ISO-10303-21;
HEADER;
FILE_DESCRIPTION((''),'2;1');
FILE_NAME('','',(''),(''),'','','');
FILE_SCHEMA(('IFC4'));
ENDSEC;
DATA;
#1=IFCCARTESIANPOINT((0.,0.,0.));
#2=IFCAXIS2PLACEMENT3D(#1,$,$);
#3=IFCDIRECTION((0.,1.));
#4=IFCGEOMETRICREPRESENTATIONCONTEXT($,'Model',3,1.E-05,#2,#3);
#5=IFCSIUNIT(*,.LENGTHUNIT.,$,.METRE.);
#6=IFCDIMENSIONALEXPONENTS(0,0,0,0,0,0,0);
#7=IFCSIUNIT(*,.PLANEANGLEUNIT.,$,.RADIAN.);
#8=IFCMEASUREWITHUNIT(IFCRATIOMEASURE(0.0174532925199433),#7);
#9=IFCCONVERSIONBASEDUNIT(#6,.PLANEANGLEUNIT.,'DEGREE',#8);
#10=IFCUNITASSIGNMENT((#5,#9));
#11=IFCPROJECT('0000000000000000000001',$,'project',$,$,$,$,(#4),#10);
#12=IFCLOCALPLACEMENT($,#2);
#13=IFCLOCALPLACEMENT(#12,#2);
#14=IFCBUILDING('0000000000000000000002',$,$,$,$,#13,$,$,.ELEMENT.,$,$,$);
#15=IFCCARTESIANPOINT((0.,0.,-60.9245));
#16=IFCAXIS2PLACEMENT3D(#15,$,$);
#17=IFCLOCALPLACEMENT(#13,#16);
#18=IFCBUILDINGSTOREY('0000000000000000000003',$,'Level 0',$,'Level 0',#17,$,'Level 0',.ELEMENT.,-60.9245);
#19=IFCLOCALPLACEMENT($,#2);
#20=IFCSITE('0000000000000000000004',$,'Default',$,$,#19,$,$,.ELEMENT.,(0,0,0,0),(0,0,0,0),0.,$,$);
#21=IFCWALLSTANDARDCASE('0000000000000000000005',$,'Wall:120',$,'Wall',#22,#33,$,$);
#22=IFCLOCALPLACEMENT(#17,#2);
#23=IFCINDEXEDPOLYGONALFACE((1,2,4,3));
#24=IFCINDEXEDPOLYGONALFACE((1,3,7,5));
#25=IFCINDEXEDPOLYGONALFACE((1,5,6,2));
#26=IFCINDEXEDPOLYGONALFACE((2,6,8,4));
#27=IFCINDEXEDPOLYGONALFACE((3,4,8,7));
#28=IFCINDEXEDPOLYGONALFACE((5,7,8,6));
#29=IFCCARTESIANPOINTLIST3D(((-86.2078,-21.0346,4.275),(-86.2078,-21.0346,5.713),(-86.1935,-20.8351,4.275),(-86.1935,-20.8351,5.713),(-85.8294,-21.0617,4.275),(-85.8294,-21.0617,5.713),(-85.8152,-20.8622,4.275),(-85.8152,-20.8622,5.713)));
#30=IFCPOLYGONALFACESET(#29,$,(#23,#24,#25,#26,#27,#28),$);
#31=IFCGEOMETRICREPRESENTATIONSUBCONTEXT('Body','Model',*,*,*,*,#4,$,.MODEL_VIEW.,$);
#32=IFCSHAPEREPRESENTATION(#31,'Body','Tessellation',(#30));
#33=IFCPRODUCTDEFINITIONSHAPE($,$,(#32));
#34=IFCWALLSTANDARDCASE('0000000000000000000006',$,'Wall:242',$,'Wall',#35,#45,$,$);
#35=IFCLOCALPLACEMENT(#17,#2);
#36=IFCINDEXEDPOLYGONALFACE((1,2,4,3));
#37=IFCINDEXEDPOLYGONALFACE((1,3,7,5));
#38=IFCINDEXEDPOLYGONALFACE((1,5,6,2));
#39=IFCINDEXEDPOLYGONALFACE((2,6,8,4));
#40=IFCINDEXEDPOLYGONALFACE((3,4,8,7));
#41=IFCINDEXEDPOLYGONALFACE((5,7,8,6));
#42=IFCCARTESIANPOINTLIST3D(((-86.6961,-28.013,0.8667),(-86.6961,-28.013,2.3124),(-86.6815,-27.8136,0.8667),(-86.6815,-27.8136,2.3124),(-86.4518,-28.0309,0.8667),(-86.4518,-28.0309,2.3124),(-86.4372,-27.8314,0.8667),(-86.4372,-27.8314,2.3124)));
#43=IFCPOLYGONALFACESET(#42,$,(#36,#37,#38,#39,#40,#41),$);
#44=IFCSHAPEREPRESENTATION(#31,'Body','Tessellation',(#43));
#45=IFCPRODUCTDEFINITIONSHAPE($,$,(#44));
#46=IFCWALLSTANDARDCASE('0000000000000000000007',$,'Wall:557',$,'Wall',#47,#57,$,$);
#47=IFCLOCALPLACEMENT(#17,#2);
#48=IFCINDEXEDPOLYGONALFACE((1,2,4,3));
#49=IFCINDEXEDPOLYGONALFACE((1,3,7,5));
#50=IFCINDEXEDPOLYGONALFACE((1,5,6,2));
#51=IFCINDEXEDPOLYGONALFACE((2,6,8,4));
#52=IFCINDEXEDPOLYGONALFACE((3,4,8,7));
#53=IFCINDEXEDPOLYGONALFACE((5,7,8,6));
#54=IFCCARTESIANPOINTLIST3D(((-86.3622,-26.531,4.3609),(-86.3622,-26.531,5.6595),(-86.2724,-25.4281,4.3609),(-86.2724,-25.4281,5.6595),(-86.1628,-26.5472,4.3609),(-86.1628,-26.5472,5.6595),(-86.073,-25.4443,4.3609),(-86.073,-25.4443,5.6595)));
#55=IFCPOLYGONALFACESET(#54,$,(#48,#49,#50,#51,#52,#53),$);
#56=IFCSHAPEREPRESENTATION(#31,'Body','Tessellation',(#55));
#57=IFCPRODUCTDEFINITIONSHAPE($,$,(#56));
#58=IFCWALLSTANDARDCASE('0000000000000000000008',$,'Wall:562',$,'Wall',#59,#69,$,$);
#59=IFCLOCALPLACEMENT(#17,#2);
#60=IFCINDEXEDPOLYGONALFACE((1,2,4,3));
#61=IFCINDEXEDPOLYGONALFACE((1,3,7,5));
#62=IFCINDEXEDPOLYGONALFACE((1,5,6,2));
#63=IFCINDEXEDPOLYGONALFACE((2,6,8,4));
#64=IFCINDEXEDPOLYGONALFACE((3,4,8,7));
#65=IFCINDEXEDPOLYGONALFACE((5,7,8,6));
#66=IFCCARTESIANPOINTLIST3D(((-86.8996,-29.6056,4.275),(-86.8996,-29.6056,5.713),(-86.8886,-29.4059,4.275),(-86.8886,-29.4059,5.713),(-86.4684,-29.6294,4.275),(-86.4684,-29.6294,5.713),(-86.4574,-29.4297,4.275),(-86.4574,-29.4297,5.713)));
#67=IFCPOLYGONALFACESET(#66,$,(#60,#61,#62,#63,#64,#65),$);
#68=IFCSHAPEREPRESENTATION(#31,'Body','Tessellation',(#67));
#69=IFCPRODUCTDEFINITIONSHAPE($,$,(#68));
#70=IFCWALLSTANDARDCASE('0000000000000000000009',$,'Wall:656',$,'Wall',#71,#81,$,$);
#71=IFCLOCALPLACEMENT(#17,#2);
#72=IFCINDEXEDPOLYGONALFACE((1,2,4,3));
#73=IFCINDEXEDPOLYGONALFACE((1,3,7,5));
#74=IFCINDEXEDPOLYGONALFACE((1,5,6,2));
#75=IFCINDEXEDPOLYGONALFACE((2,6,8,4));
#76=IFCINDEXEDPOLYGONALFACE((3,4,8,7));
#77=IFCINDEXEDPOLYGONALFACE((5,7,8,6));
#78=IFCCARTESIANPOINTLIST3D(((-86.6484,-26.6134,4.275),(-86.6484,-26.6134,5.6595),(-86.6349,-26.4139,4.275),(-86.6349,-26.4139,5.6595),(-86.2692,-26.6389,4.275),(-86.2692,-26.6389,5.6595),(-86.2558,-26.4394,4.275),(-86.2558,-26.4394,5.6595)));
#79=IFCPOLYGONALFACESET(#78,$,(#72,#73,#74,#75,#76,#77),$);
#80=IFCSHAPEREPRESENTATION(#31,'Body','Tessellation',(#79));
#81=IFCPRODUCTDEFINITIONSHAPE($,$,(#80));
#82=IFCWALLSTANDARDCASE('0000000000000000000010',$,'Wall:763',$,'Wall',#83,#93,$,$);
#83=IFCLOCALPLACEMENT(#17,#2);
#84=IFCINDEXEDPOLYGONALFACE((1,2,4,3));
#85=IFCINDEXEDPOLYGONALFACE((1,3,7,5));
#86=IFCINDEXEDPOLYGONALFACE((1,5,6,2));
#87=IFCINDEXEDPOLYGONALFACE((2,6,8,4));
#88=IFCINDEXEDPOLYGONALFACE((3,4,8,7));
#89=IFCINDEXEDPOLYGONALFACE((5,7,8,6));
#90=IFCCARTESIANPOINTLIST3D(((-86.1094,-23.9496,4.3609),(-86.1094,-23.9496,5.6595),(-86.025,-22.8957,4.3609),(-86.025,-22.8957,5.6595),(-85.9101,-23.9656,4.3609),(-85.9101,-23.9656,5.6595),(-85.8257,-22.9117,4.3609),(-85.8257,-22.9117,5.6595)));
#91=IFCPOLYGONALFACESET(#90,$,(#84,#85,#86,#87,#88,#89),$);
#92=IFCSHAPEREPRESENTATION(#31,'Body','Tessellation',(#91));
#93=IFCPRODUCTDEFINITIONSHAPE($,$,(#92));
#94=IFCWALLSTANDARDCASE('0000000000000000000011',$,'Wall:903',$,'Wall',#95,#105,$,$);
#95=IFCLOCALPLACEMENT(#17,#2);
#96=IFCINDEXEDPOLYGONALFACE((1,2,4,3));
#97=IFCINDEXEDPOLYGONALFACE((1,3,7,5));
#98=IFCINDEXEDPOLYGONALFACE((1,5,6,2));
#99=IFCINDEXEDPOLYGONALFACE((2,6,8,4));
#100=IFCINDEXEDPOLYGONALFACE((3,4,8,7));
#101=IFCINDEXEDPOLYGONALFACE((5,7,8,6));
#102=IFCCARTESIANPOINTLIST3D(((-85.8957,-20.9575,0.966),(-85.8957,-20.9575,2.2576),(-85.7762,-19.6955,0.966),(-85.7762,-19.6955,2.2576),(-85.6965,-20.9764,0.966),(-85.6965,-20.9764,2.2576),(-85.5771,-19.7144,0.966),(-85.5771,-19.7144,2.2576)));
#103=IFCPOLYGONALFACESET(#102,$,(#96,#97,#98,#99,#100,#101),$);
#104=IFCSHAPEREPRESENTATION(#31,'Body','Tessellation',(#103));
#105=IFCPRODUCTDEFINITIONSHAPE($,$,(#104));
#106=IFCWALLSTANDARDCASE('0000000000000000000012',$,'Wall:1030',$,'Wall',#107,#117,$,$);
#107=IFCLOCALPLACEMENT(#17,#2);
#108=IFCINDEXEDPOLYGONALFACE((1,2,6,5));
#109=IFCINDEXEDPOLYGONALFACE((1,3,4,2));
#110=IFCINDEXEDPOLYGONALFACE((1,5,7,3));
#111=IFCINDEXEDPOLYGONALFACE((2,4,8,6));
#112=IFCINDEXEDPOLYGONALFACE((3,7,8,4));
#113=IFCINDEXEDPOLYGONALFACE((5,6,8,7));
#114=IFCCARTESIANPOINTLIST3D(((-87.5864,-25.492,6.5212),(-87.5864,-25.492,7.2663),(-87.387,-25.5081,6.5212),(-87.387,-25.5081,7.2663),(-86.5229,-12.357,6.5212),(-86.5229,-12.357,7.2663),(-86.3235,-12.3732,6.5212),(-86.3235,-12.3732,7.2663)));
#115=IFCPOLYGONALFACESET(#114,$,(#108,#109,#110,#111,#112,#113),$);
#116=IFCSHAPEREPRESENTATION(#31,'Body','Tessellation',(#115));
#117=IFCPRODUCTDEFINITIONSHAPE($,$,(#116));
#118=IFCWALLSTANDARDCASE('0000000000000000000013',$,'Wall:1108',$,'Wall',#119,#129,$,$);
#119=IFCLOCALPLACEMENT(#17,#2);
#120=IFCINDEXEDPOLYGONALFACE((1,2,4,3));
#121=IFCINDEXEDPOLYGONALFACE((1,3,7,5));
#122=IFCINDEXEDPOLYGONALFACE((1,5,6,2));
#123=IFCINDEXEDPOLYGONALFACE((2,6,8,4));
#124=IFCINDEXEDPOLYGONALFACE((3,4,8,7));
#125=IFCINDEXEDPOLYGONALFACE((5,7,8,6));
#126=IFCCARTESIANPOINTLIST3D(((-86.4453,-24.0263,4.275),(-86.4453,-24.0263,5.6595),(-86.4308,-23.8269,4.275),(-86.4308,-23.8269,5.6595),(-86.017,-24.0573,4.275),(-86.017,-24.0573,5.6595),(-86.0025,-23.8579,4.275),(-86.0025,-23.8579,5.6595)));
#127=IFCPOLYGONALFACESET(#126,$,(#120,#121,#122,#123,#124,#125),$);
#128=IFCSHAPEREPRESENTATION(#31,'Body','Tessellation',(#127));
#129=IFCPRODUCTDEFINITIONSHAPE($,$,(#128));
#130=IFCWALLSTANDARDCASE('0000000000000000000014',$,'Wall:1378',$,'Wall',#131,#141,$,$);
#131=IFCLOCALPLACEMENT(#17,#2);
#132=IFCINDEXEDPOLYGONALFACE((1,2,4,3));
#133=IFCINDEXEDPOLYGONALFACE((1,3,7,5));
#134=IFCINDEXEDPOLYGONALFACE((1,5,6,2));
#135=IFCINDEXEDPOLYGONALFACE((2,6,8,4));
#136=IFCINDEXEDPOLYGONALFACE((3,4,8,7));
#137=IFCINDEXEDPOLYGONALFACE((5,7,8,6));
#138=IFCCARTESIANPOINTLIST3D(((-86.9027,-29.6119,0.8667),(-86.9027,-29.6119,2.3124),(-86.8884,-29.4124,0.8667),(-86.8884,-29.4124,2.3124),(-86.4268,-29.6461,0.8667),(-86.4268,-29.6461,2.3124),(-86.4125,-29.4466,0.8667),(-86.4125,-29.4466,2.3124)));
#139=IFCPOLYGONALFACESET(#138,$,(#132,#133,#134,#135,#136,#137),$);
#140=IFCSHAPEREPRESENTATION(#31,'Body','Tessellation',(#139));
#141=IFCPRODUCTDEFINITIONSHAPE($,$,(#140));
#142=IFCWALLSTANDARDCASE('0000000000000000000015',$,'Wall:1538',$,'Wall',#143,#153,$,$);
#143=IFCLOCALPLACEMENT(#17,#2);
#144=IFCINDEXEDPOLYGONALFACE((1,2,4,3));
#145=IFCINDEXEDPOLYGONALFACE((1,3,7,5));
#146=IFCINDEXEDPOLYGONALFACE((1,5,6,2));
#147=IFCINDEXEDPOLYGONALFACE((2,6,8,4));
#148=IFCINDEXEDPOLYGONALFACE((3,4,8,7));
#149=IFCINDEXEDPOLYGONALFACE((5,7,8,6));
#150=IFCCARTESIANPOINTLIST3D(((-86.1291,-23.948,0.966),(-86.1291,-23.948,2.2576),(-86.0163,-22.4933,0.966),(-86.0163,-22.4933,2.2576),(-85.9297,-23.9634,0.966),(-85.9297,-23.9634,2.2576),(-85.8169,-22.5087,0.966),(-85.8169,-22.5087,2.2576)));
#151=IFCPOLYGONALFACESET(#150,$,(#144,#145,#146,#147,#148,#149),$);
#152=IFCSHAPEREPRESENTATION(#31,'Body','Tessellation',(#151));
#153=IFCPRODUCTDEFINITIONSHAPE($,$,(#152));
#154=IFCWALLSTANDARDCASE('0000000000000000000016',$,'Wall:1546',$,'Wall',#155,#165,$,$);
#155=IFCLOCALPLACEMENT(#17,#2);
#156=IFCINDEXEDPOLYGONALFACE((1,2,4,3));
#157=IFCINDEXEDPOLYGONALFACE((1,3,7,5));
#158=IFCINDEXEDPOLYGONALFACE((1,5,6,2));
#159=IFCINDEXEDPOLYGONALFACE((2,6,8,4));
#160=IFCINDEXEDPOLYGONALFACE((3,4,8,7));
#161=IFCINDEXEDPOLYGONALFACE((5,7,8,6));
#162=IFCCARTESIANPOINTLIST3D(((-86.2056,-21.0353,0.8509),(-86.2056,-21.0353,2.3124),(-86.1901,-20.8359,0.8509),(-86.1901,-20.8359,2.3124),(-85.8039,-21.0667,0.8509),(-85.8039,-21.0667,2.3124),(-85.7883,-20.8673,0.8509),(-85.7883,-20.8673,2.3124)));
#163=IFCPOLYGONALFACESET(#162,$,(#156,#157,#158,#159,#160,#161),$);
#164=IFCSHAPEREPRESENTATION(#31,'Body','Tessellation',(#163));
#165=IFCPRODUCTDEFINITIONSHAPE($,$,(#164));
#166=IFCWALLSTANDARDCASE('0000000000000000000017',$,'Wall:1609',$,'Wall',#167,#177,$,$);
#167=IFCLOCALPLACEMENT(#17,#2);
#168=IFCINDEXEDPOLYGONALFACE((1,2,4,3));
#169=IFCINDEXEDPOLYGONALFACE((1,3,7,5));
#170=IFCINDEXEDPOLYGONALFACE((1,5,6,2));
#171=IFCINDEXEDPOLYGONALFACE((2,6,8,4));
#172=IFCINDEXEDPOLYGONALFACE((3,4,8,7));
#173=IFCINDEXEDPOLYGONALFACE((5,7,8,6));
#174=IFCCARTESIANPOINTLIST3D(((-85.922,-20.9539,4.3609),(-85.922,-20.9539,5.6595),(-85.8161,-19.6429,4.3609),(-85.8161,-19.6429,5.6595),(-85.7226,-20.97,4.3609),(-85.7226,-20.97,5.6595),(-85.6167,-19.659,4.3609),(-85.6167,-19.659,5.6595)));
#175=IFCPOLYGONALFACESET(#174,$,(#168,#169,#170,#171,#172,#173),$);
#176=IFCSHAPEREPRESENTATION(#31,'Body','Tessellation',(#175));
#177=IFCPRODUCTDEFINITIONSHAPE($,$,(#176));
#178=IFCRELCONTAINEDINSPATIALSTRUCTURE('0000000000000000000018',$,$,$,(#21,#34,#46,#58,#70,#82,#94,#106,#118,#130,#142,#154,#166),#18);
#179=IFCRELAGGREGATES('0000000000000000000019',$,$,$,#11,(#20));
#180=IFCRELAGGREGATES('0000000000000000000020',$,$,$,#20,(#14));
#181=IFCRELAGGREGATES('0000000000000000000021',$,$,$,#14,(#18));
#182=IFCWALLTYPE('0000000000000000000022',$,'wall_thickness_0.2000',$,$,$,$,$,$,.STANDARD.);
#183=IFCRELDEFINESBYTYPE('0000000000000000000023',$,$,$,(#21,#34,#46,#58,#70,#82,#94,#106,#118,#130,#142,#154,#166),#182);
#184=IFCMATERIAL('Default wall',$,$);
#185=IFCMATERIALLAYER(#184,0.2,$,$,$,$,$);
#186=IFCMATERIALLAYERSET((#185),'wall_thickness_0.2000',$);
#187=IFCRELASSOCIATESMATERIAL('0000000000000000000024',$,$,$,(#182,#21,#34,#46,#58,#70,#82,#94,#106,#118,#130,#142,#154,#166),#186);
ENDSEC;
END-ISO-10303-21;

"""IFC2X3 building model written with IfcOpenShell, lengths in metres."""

from ifc_helpers import new_model, entity, si_unit, converted_unit, direction, frame, origin, place, context, subcontext, project, spatial, polyline, outline, extrude, material, layer, layer_set, layer_usage, type_object, element, save


model = new_model("IFC2X3")

# Units and contexts
model_context = context("Model", 3, precision=1e-05, world=origin(), true_north=direction((0.0, 1.0)))
body_context = subcontext(model_context, "Body", "Model", "MODEL_VIEW")
ifc_project = project(units=[si_unit("LENGTHUNIT", "METRE"), converted_unit("PLANEANGLEUNIT", "DEGREE", entity("IfcRatioMeasure", 0.0174532925199433), si_unit("PLANEANGLEUNIT", "RADIAN"), dimensions=[0, 0, 0, 0, 0, 0, 0])], contexts=[model_context])

# Site, building, storey
site_placement = place(None, origin())
site = spatial("IfcSite", under=ifc_project, at=site_placement, Name="Default", CompositionType="ELEMENT", RefLatitude=(0, 0, 0, 0), RefLongitude=(0, 0, 0, 0), RefElevation=0.0)
placement_1 = place(None, origin())
building_placement = place(placement_1, origin())
building = spatial("IfcBuilding", under=site, at=building_placement, CompositionType="ELEMENT")
storey_placement = place(building_placement, frame((0.0, 0.0, -60.9245)))
storey = spatial("IfcBuildingStorey", under=building, at=storey_placement, Name="Level 0", ObjectType="Level 0", LongName="Level 0", CompositionType="ELEMENT", Elevation=-60.9245)

# Walls
ifc_material = material(Name="Default wall")
ifc_layer = layer(ifc_material, 0.2)
ifc_layer_set = layer_set([ifc_layer], Name="wall_thickness_0.2000")
ifc_layer_usage = layer_usage(ifc_layer_set, "AXIS2", "POSITIVE", -0.1)
wall_type = type_object("IfcWallType", Name="wall_thickness_0.2000", PredefinedType="STANDARD", material=ifc_layer_set)
placement_2 = place(building_placement, frame((0.0, 0.0, -56.6495)))
wall_1_placement = place(placement_2, frame((-85.8223, -20.9619, 0.0), z_axis=(0.0, 0.0, 1.0), x_axis=(-0.997445, 0.071444, 0.0)))
element("IfcWallStandardCase", 1, at=wall_1_placement, inside=storey, type_object=wall_type, material=ifc_layer_usage, Name="Wall:120", ObjectType="Wall", context=body_context, shape_type="SweptSolid", body=[
    extrude(outline(polyline([(0.3793, -0.1), (0.3793, 0.1), (0.0, 0.1), (0.0, -0.1), (0.3793, -0.1)])), origin(), (0.0, 0.0, 1.0), 1.438),
])
placement_3 = place(building_placement, frame((0.0, 0.0, -60.0578)))
wall_2_placement = place(placement_3, frame((-86.4445, -27.9312, 0.0), z_axis=(0.0, 0.0, 1.0), x_axis=(-0.997337, 0.072931, 0.0)))
element("IfcWallStandardCase", 2, at=wall_2_placement, inside=storey, type_object=wall_type, material=ifc_layer_usage, Name="Wall:242", ObjectType="Wall", context=body_context, shape_type="SweptSolid", body=[
    extrude(outline(polyline([(0.245, -0.1), (0.245, 0.1), (0.0, 0.1), (0.0, -0.1), (0.245, -0.1)])), origin(), (0.0, 0.0, 1.0), 1.4457),
])
placement_4 = place(building_placement, frame((0.0, 0.0, -56.5636)))
wall_3_placement = place(placement_4, frame((-86.1727, -25.4362, 0.0), z_axis=(0.0, 0.0, 1.0), x_axis=(-0.081122, -0.996704, 0.0)))
element("IfcWallStandardCase", 3, at=wall_3_placement, inside=storey, type_object=wall_type, material=ifc_layer_usage, Name="Wall:557", ObjectType="Wall", context=body_context, shape_type="SweptSolid", body=[
    extrude(outline(polyline([(1.1066, -0.1), (1.1066, 0.1), (0.0, 0.1), (0.0, -0.1), (1.1066, -0.1)])), origin(), (0.0, 0.0, 1.0), 1.2985),
])
placement_5 = place(building_placement, frame((0.0, 0.0, -56.6495)))
wall_4_placement = place(placement_5, frame((-86.4629, -29.5296, 0.0), z_axis=(0.0, 0.0, 1.0), x_axis=(-0.998476, 0.055181, 0.0)))
element("IfcWallStandardCase", 4, at=wall_4_placement, inside=storey, type_object=wall_type, material=ifc_layer_usage, Name="Wall:562", ObjectType="Wall", context=body_context, shape_type="SweptSolid", body=[
    extrude(outline(polyline([(0.4319, -0.1), (0.4319, 0.1), (0.0, 0.1), (0.0, -0.1), (0.4319, -0.1)])), origin(), (0.0, 0.0, 1.0), 1.438),
])
placement_6 = place(building_placement, frame((0.0, 0.0, -56.6495)))
wall_5_placement = place(placement_6, frame((-86.2625, -26.5391, 0.0), z_axis=(0.0, 0.0, 1.0), x_axis=(-0.997749, 0.067065, 0.0)))
element("IfcWallStandardCase", 5, at=wall_5_placement, inside=storey, type_object=wall_type, material=ifc_layer_usage, Name="Wall:656", ObjectType="Wall", context=body_context, shape_type="SweptSolid", body=[
    extrude(outline(polyline([(0.38, -0.1), (0.38, 0.1), (0.0, 0.1), (0.0, -0.1), (0.38, -0.1)])), origin(), (0.0, 0.0, 1.0), 1.3845),
])
placement_7 = place(building_placement, frame((0.0, 0.0, -56.5636)))
wall_6_placement = place(placement_7, frame((-85.9253, -22.9037, 0.0), z_axis=(0.0, 0.0, 1.0), x_axis=(-0.079818, -0.996809, 0.0)))
element("IfcWallStandardCase", 6, at=wall_6_placement, inside=storey, type_object=wall_type, material=ifc_layer_usage, Name="Wall:763", ObjectType="Wall", context=body_context, shape_type="SweptSolid", body=[
    extrude(outline(polyline([(1.0573, -0.1), (1.0573, 0.1), (0.0, 0.1), (0.0, -0.1), (1.0573, -0.1)])), origin(), (0.0, 0.0, 1.0), 1.2985),
])
placement_8 = place(building_placement, frame((0.0, 0.0, -59.9585)))
wall_7_placement = place(placement_8, frame((-85.6766, -19.7049, 0.0), z_axis=(0.0, 0.0, 1.0), x_axis=(-0.094255, -0.995548, 0.0)))
element("IfcWallStandardCase", 7, at=wall_7_placement, inside=storey, type_object=wall_type, material=ifc_layer_usage, Name="Wall:903", ObjectType="Wall", context=body_context, shape_type="SweptSolid", body=[
    extrude(outline(polyline([(1.2677, -0.1), (1.2677, 0.1), (0.0, 0.1), (0.0, -0.1), (1.2677, -0.1)])), origin(), (0.0, 0.0, 1.0), 1.2916),
])
placement_9 = place(building_placement, frame((0.0, 0.0, -54.4033)))
wall_8_placement = place(placement_9, frame((-87.4867, -25.5001, 0.0), z_axis=(0.0, 0.0, 1.0), x_axis=(0.080704, 0.996738, 0.0)))
element("IfcWallStandardCase", 8, at=wall_8_placement, inside=storey, type_object=wall_type, material=ifc_layer_usage, Name="Wall:1030", ObjectType="Wall", context=body_context, shape_type="SweptSolid", body=[
    extrude(outline(polyline([(13.1779, -0.1), (13.1779, 0.1), (0.0, 0.1), (0.0, -0.1), (13.1779, -0.1)])), origin(), (0.0, 0.0, 1.0), 0.7451),
])
placement_10 = place(building_placement, frame((0.0, 0.0, -56.6495)))
wall_9_placement = place(placement_10, frame((-86.0097, -23.9576, 0.0), z_axis=(0.0, 0.0, 1.0), x_axis=(-0.997388, 0.072225, 0.0)))
element("IfcWallStandardCase", 9, at=wall_9_placement, inside=storey, type_object=wall_type, material=ifc_layer_usage, Name="Wall:1108", ObjectType="Wall", context=body_context, shape_type="SweptSolid", body=[
    extrude(outline(polyline([(0.4294, -0.1), (0.4294, 0.1), (0.0, 0.1), (0.0, -0.1), (0.4294, -0.1)])), origin(), (0.0, 0.0, 1.0), 1.3845),
])
placement_11 = place(building_placement, frame((0.0, 0.0, -60.0578)))
wall_10_placement = place(placement_11, frame((-86.4196, -29.5463, 0.0), z_axis=(0.0, 0.0, 1.0), x_axis=(-0.997432, 0.07162, 0.0)))
element("IfcWallStandardCase", 10, at=wall_10_placement, inside=storey, type_object=wall_type, material=ifc_layer_usage, Name="Wall:1378", ObjectType="Wall", context=body_context, shape_type="SweptSolid", body=[
    extrude(outline(polyline([(0.4772, -0.1), (0.4772, 0.1), (0.0, 0.1), (0.0, -0.1), (0.4772, -0.1)])), origin(), (0.0, 0.0, 1.0), 1.4457),
])
placement_12 = place(building_placement, frame((0.0, 0.0, -59.9585)))
wall_11_placement = place(placement_12, frame((-85.9166, -22.501, 0.0), z_axis=(0.0, 0.0, 1.0), x_axis=(-0.077269, -0.99701, 0.0)))
element("IfcWallStandardCase", 11, at=wall_11_placement, inside=storey, type_object=wall_type, material=ifc_layer_usage, Name="Wall:1538", ObjectType="Wall", context=body_context, shape_type="SweptSolid", body=[
    extrude(outline(polyline([(1.459, -0.1), (1.459, 0.1), (0.0, 0.1), (0.0, -0.1), (1.459, -0.1)])), origin(), (0.0, 0.0, 1.0), 1.2916),
])
placement_13 = place(building_placement, frame((0.0, 0.0, -60.0736)))
wall_12_placement = place(placement_13, frame((-85.7961, -20.967, 0.0), z_axis=(0.0, 0.0, 1.0), x_axis=(-0.99697, 0.077789, 0.0)))
element("IfcWallStandardCase", 12, at=wall_12_placement, inside=storey, type_object=wall_type, material=ifc_layer_usage, Name="Wall:1546", ObjectType="Wall", context=body_context, shape_type="SweptSolid", body=[
    extrude(outline(polyline([(0.403, -0.1), (0.403, 0.1), (0.0, 0.1), (0.0, -0.1), (0.403, -0.1)])), origin(), (0.0, 0.0, 1.0), 1.4615),
])
placement_14 = place(building_placement, frame((0.0, 0.0, -56.5636)))
wall_13_placement = place(placement_14, frame((-85.7164, -19.6509, 0.0), z_axis=(0.0, 0.0, 1.0), x_axis=(-0.080543, -0.996751, 0.0)))
element("IfcWallStandardCase", 13, at=wall_13_placement, inside=storey, type_object=wall_type, material=ifc_layer_usage, Name="Wall:1609", ObjectType="Wall", context=body_context, shape_type="SweptSolid", body=[
    extrude(outline(polyline([(1.3153, -0.1), (1.3153, 0.1), (0.0, 0.1), (0.0, -0.1), (1.3153, -0.1)])), origin(), (0.0, 0.0, 1.0), 1.2985),
])

save(model, "model.ifc")
